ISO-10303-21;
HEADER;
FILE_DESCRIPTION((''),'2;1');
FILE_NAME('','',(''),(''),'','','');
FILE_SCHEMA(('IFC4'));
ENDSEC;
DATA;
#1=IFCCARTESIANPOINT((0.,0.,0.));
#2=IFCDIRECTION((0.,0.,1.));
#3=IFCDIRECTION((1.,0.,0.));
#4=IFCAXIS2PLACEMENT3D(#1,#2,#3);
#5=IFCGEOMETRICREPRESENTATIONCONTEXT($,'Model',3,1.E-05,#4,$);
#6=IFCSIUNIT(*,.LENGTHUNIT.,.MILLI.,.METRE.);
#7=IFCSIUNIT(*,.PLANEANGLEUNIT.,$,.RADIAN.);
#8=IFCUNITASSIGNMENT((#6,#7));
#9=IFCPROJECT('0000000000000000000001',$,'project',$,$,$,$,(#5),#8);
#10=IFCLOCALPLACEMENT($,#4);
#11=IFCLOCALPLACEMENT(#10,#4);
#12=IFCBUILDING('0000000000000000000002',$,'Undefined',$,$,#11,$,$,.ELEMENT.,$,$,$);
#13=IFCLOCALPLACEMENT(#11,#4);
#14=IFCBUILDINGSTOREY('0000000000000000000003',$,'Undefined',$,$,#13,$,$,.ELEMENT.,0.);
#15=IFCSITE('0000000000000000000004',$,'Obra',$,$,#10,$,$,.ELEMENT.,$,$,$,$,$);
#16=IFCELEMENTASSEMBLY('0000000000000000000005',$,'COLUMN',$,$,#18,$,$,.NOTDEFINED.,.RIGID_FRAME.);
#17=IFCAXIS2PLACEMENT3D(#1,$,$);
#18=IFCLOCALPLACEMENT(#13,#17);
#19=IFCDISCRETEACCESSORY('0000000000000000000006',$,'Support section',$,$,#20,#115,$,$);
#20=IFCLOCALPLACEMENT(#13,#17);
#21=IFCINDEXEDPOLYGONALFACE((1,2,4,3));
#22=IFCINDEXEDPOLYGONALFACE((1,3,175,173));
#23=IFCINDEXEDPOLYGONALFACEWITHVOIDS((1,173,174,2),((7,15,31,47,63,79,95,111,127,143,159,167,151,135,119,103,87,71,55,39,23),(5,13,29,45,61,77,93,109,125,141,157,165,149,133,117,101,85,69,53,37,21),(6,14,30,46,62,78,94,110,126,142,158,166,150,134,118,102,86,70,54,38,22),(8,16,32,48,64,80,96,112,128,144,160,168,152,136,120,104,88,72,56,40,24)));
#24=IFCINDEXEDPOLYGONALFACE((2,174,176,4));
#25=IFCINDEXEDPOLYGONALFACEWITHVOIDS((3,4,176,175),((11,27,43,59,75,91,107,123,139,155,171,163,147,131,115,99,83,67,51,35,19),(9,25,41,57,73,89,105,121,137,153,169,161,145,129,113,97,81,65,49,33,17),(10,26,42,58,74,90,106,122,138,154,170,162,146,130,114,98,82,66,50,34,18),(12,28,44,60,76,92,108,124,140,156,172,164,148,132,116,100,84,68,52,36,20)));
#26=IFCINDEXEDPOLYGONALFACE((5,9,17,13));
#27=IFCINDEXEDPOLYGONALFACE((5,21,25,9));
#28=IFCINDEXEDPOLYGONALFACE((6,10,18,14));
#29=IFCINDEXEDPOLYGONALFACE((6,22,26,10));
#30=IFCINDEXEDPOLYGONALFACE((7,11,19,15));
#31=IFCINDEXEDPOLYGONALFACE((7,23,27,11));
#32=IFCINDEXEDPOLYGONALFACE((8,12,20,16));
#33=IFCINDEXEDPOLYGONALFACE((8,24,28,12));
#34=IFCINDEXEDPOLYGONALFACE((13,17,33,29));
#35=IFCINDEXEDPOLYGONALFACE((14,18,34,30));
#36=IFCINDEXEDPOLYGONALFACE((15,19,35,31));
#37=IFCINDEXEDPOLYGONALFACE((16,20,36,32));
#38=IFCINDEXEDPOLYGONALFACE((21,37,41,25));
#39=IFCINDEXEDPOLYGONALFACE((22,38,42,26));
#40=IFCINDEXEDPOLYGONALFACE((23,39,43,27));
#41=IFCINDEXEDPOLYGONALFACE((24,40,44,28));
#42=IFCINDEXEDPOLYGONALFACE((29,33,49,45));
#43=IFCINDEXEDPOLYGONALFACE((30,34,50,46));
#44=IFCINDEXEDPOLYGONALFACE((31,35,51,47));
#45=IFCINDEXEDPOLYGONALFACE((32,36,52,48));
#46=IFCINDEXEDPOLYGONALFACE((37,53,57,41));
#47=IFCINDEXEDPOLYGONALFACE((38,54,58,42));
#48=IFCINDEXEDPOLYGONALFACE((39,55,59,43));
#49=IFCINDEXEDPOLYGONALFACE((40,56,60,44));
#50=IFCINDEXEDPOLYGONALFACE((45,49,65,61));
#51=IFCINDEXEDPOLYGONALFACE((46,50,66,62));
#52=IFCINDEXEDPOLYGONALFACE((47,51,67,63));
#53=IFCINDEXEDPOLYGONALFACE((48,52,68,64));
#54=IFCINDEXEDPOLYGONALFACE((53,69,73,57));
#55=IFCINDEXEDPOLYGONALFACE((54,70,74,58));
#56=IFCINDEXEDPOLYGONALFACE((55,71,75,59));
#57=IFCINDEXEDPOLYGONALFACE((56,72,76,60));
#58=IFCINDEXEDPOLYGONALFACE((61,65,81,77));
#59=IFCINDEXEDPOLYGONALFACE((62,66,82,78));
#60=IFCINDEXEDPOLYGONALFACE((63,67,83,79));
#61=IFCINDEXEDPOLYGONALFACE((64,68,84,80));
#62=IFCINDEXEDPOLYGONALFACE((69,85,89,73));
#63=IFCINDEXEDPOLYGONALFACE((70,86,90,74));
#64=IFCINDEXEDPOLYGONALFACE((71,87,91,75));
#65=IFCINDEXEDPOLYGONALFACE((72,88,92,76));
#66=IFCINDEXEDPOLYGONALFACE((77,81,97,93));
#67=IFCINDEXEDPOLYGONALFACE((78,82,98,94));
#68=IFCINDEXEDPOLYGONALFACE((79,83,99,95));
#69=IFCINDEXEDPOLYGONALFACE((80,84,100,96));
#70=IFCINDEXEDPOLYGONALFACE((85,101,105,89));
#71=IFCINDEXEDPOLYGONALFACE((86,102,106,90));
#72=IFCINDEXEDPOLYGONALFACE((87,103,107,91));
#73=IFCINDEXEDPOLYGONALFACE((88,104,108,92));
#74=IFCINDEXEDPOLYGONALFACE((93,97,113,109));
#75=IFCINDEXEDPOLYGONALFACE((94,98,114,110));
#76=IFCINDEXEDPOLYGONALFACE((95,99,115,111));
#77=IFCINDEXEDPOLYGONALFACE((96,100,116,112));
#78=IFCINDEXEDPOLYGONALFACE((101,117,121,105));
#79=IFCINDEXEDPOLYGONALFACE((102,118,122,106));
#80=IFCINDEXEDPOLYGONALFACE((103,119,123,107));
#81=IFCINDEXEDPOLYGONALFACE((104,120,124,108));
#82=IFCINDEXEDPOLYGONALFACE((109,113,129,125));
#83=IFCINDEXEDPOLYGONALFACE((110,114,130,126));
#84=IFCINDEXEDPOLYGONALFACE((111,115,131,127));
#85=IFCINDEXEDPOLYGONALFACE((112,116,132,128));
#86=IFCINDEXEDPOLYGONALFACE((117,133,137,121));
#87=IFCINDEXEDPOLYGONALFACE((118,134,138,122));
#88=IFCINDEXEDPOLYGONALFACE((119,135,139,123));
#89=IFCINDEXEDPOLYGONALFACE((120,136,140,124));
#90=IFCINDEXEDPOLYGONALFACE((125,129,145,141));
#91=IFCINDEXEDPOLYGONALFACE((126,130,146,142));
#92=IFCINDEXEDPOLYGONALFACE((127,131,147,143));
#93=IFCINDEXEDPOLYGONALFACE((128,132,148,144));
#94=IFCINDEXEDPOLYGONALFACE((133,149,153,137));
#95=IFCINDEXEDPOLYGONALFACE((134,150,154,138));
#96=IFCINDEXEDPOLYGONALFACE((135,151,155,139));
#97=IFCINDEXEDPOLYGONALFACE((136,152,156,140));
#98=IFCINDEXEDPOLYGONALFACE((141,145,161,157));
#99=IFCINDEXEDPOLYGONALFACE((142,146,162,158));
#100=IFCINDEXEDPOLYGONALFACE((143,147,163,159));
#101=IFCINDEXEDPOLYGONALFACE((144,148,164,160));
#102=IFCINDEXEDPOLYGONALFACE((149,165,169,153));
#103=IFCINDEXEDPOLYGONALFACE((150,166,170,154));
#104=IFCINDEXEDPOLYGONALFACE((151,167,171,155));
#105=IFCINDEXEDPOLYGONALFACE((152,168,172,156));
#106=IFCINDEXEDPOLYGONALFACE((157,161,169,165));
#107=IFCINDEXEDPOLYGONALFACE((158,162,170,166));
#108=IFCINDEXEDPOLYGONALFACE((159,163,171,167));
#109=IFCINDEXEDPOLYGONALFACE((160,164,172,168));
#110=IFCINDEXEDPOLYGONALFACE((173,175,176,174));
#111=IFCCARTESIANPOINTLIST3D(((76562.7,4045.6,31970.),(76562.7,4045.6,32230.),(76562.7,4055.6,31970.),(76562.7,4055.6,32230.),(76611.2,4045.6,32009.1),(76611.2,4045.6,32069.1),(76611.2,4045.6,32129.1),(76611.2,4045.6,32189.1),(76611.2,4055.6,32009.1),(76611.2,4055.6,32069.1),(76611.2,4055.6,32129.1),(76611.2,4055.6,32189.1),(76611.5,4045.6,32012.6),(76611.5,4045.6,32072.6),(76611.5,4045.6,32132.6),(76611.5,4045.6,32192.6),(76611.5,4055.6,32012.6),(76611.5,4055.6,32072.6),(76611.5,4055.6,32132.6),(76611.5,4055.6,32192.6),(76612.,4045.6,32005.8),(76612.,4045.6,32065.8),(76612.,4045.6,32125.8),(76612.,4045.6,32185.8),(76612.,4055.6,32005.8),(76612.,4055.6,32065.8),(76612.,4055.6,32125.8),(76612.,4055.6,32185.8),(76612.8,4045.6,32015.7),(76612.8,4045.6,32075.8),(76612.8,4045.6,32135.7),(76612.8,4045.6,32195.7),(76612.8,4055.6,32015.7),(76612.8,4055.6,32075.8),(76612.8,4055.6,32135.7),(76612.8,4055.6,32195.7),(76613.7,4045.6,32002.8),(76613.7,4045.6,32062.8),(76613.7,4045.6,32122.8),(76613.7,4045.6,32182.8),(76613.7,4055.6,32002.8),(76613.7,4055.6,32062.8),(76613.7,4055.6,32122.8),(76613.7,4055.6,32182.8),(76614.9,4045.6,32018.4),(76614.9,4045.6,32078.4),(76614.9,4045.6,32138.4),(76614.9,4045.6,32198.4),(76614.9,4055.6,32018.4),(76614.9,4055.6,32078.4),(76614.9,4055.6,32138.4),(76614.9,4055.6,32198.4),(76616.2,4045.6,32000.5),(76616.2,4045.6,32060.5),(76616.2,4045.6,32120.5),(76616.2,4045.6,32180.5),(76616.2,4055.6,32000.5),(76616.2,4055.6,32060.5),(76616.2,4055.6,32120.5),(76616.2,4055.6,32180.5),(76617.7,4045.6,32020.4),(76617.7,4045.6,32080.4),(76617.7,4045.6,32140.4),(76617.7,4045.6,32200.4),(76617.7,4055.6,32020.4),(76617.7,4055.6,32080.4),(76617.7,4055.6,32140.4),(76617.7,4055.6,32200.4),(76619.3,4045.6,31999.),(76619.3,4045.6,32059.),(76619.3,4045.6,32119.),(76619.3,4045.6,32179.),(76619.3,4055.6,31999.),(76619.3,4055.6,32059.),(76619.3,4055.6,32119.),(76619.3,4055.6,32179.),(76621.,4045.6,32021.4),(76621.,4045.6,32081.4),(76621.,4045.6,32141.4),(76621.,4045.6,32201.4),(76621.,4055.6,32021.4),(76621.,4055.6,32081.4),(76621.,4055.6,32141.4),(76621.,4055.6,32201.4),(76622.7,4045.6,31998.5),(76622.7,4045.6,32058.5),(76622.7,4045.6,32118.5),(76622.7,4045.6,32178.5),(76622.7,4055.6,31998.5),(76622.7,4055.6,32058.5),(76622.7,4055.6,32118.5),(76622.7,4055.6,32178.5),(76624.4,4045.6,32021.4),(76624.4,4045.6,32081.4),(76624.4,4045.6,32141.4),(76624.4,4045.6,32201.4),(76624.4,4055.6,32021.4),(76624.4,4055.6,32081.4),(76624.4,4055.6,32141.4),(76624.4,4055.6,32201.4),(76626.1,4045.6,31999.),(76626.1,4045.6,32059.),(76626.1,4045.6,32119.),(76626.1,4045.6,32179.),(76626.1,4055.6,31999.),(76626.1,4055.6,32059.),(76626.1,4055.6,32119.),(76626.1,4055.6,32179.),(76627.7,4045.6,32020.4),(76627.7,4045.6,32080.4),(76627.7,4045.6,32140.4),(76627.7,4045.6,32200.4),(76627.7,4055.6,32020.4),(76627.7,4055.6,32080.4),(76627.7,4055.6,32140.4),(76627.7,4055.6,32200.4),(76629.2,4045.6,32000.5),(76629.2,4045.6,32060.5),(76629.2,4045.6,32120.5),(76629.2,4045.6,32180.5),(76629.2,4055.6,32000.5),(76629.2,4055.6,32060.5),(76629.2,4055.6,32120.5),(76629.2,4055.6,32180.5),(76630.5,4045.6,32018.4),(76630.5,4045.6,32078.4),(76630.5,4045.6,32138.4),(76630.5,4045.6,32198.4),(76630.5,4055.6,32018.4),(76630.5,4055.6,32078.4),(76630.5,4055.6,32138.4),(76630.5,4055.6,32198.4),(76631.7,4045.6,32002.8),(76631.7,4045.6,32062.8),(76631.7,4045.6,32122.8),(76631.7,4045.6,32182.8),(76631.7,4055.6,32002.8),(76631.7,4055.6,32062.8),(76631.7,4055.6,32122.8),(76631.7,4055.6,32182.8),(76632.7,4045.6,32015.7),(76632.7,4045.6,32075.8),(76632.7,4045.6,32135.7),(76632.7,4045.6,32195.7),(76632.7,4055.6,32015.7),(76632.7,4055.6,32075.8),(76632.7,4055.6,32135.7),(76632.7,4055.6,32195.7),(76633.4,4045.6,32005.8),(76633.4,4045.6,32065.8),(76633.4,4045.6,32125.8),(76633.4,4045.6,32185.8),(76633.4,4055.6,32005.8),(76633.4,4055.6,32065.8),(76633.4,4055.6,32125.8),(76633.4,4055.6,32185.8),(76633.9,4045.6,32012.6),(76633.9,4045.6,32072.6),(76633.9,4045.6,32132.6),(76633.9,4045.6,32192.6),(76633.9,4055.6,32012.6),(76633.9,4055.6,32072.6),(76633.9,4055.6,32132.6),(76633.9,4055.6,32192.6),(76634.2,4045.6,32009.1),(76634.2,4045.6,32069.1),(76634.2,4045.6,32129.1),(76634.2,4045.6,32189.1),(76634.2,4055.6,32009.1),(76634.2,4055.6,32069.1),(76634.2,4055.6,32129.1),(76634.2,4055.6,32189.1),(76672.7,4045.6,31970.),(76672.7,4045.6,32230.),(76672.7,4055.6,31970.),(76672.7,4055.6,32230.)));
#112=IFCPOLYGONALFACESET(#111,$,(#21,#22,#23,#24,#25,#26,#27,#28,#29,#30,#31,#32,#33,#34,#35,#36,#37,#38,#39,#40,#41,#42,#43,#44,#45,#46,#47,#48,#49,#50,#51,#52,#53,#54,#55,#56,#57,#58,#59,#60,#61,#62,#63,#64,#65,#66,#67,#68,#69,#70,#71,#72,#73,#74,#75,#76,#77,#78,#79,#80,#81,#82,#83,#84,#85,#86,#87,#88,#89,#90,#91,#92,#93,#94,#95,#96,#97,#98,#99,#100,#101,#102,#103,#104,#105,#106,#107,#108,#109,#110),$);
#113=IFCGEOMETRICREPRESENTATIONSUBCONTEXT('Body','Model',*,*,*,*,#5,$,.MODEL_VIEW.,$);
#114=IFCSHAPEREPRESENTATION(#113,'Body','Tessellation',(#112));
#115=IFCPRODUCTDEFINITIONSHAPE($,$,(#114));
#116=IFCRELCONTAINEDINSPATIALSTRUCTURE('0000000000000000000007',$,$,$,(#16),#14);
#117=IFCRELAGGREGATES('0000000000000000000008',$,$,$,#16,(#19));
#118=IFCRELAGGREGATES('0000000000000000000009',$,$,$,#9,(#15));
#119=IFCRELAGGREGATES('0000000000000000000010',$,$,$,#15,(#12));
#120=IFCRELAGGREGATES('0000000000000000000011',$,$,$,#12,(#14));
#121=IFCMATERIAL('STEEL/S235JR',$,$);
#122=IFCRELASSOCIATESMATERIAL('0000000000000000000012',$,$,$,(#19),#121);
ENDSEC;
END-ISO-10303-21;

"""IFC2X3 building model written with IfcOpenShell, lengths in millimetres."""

from ifc_helpers import new_model, si_unit, frame, origin_with_axes, origin_2d_with_axis, place, context, subcontext, project, spatial, rectangle, circle, extrude, source, transform, mapped, material, element, aggregate, save


model = new_model("IFC2X3")

# Units and contexts
model_context = context("Model", 3, precision=1e-05, world=origin_with_axes())
body_context = subcontext(model_context, "Body", "Model", "MODEL_VIEW")
ifc_project = project(units=[si_unit("LENGTHUNIT", "METRE", prefix="MILLI"), si_unit("PLANEANGLEUNIT", "RADIAN")], contexts=[model_context])

# Site, building, storey
site_placement = place(None, origin_with_axes())
site = spatial("IfcSite", under=ifc_project, at=site_placement, Name="Obra", CompositionType="ELEMENT")
building_placement = place(site_placement, origin_with_axes())
building = spatial("IfcBuilding", under=site, at=building_placement, Name="Undefined", CompositionType="ELEMENT")
storey_placement = place(building_placement, origin_with_axes())
storey = spatial("IfcBuildingStorey", under=building, at=storey_placement, Name="Undefined", CompositionType="ELEMENT", Elevation=0.0)

# Shared definitions
ifc_material_1 = material(Name="STEEL/S235JR")

# Element assembly, discrete accessory, opening
assembly_1_placement = place(storey_placement, origin_with_axes())
assembly_1 = element("IfcElementAssembly", 1, at=assembly_1_placement, inside=storey, Name="COLUMN", AssemblyPlace="NOTDEFINED", PredefinedType="RIGID_FRAME")
shared_shape_1 = source(origin_with_axes(), body_context, "Body", "SweptSolid", [
    extrude(circle(Radius=11.5, at=origin_2d_with_axis()), frame((0.0, -14.4, 0.0), z_axis=(0.0, 1.0, 0.0), x_axis=(1.0, 0.0, 0.0)), (0.0, 0.0, 1.0), 10.2),
])
discrete_accessory_1_placement = place(assembly_1_placement, frame((76617.7, 4050.6, 31970.0), z_axis=(0.0, 0.0, 1.0), x_axis=(-1.0, 0.0, 0.0)))
discrete_accessory_1 = element("IfcDiscreteAccessory", 2, at=discrete_accessory_1_placement, material=ifc_material_1, Name="Support section", context=body_context, shape_type="SweptSolid", body=[
    extrude(rectangle(XDim=10.0, YDim=110.0, at=origin_2d_with_axis()), frame((0.0, 0.0, 260.0), z_axis=(0.0, 0.0, -1.0), x_axis=(0.0, 1.0, 0.0)), (0.0, 0.0, 1.0), 260.0),
])
opening_1_placement = place(assembly_1_placement, frame((76572.7, 4059.9, 32300.0), z_axis=(1.0, 0.0, 0.0), x_axis=(0.0, 0.0, -1.0)))
element("IfcOpeningElement", 3, at=opening_1_placement, cuts=discrete_accessory_1, ObjectType="Opening", context=body_context, shape_type="MappedRepresentation", body=[
    mapped(shared_shape_1, transform((110.0, 0.0, 50.0))),
    mapped(shared_shape_1, transform((170.0, 0.0, 50.0))),
    mapped(shared_shape_1, transform((230.0, 0.0, 50.0))),
    mapped(shared_shape_1, transform((290.0, 0.0, 50.0))),
])

aggregate(assembly_1, [discrete_accessory_1])

save(model, "model.ifc")
